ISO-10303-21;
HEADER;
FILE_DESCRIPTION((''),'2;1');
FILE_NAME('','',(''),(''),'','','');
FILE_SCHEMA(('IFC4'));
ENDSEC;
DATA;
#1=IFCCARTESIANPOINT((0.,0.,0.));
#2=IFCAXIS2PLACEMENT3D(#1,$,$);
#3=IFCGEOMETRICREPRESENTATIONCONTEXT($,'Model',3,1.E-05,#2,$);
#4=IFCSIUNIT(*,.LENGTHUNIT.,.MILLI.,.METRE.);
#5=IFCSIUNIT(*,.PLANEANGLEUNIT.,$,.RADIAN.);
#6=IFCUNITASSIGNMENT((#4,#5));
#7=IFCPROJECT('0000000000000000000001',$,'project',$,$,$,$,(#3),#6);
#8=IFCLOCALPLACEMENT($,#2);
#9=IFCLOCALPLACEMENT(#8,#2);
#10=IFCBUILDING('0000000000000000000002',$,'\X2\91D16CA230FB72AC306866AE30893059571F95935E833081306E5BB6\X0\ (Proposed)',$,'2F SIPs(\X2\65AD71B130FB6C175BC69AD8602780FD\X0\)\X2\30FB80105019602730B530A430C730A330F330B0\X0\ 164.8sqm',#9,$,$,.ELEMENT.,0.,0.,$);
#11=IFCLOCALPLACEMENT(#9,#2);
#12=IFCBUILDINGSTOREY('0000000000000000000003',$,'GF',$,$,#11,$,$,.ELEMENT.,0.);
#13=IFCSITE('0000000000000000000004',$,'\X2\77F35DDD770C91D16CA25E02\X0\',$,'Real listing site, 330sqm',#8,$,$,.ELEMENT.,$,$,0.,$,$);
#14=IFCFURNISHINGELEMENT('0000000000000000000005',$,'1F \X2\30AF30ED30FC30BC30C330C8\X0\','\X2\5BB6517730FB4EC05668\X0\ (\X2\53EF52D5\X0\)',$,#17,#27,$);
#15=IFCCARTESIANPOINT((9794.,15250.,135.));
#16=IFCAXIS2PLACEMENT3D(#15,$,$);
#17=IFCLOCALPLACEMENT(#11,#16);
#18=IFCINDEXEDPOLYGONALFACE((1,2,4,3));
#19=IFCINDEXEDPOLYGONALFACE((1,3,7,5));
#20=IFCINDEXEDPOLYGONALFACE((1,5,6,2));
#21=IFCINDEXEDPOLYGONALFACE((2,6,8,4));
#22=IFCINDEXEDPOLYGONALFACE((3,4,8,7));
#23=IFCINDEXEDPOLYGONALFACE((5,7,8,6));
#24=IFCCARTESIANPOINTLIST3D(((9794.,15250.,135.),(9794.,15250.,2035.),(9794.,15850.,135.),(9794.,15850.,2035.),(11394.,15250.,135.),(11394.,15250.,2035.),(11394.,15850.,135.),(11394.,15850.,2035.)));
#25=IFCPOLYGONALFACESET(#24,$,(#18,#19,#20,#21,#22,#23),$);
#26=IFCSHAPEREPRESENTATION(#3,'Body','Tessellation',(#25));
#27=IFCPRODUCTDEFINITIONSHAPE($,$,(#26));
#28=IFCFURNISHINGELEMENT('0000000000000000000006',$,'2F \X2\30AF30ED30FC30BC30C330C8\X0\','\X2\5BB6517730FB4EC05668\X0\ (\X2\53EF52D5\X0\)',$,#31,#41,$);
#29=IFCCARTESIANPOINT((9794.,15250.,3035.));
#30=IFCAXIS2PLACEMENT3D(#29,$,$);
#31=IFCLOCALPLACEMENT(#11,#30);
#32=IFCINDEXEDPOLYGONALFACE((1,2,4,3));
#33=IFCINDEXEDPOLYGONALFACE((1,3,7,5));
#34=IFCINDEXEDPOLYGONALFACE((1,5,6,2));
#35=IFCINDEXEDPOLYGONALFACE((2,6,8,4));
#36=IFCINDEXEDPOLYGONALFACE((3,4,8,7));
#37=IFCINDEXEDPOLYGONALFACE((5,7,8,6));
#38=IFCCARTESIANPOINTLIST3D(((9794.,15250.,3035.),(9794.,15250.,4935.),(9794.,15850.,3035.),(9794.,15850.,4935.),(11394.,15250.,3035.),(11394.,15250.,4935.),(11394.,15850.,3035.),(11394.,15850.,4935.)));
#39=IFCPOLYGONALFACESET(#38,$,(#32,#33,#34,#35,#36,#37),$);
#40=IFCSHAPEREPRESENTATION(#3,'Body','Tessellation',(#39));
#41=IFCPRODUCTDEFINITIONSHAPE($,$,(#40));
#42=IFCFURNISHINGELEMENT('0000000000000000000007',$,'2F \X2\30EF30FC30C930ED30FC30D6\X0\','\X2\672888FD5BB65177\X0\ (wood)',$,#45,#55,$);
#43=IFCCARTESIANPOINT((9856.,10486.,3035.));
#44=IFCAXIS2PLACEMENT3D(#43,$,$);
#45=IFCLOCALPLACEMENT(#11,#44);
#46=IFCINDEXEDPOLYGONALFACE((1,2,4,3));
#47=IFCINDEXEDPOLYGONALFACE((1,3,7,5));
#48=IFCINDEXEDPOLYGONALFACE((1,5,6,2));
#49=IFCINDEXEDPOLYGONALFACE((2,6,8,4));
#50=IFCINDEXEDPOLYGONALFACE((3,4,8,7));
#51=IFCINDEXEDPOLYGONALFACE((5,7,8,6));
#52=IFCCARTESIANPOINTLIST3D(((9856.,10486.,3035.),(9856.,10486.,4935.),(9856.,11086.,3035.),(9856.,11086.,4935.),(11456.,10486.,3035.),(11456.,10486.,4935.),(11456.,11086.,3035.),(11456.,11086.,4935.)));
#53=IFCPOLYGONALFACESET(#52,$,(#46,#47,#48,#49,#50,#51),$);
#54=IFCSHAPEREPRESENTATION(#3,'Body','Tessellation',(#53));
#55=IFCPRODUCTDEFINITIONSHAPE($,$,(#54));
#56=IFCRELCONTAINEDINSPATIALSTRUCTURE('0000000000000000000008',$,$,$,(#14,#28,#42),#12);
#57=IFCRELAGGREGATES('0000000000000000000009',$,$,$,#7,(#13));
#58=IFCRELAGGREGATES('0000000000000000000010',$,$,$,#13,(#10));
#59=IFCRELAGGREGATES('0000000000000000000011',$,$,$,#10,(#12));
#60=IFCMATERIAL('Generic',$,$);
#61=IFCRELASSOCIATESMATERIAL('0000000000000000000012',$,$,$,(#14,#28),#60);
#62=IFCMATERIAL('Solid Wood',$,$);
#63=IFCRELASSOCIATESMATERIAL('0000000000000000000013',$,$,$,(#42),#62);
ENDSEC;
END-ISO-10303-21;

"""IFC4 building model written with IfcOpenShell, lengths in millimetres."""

from ifc_helpers import new_model, si_unit, frame, frame_2d, origin, place, context, project, spatial, rectangle, extrude, material, element, save


model = new_model("IFC4")

# Units and contexts
model_context = context("Model", 3, precision=1e-05, world=origin())
ifc_project = project(units=[si_unit("LENGTHUNIT", "METRE", prefix="MILLI"), si_unit("PLANEANGLEUNIT", "RADIAN")], contexts=[model_context])

# Site, building, storey
site_placement = place(None, origin())
site = spatial("IfcSite", under=ifc_project, at=site_placement, Name="石川県金沢市", ObjectType="Real listing site, 330sqm", CompositionType="ELEMENT", RefElevation=0.0)
building_placement = place(site_placement, origin())
building = spatial("IfcBuilding", under=site, at=building_placement, Name="金沢・犬と暮らす土間広めの家 (Proposed)", ObjectType="2F SIPs(断熱・気密高性能)・耐候性サイディング 164.8sqm", CompositionType="ELEMENT", ElevationOfRefHeight=0.0, ElevationOfTerrain=0.0)
storey_placement = place(building_placement, origin())
storey = spatial("IfcBuildingStorey", under=building, at=storey_placement, Name="GF", CompositionType="ELEMENT", Elevation=0.0)

# Shared definitions
ifc_material_1 = material(Name="Solid Wood")

# Shared definitions
ifc_material_2 = material(Name="Generic")

# Furnishing elements
furnishing_1_placement = place(storey_placement, frame((9794.0, 15250.0, 135.0)))
element("IfcFurnishingElement", 1, at=furnishing_1_placement, inside=storey, material=ifc_material_2, Name="1F クローゼット", Description="家具・什器 (可動)", context=model_context, shape_type="SweptSolid", body=[
    extrude(rectangle(XDim=1600.0, YDim=600.0, at=frame_2d((800.0, 300.0))), frame((9794.0, 15250.0, 135.0)), (0.0, 0.0, 1.0), 1900.0),
])
furnishing_2_placement = place(storey_placement, frame((9794.0, 15250.0, 3035.0)))
element("IfcFurnishingElement", 2, at=furnishing_2_placement, inside=storey, material=ifc_material_2, Name="2F クローゼット", Description="家具・什器 (可動)", context=model_context, shape_type="SweptSolid", body=[
    extrude(rectangle(XDim=1600.0, YDim=600.0, at=frame_2d((800.0, 300.0))), frame((9794.0, 15250.0, 3035.0)), (0.0, 0.0, 1.0), 1900.0),
])
furnishing_3_placement = place(storey_placement, frame((9856.0, 10486.0, 3035.0)))
element("IfcFurnishingElement", 3, at=furnishing_3_placement, inside=storey, material=ifc_material_1, Name="2F ワードローブ", Description="木製家具 (wood)", context=model_context, shape_type="SweptSolid", body=[
    extrude(rectangle(XDim=1600.0, YDim=600.0, at=frame_2d((800.0, 300.0))), frame((9856.0, 10486.0, 3035.0)), (0.0, 0.0, 1.0), 1900.0),
])

save(model, "model.ifc")
